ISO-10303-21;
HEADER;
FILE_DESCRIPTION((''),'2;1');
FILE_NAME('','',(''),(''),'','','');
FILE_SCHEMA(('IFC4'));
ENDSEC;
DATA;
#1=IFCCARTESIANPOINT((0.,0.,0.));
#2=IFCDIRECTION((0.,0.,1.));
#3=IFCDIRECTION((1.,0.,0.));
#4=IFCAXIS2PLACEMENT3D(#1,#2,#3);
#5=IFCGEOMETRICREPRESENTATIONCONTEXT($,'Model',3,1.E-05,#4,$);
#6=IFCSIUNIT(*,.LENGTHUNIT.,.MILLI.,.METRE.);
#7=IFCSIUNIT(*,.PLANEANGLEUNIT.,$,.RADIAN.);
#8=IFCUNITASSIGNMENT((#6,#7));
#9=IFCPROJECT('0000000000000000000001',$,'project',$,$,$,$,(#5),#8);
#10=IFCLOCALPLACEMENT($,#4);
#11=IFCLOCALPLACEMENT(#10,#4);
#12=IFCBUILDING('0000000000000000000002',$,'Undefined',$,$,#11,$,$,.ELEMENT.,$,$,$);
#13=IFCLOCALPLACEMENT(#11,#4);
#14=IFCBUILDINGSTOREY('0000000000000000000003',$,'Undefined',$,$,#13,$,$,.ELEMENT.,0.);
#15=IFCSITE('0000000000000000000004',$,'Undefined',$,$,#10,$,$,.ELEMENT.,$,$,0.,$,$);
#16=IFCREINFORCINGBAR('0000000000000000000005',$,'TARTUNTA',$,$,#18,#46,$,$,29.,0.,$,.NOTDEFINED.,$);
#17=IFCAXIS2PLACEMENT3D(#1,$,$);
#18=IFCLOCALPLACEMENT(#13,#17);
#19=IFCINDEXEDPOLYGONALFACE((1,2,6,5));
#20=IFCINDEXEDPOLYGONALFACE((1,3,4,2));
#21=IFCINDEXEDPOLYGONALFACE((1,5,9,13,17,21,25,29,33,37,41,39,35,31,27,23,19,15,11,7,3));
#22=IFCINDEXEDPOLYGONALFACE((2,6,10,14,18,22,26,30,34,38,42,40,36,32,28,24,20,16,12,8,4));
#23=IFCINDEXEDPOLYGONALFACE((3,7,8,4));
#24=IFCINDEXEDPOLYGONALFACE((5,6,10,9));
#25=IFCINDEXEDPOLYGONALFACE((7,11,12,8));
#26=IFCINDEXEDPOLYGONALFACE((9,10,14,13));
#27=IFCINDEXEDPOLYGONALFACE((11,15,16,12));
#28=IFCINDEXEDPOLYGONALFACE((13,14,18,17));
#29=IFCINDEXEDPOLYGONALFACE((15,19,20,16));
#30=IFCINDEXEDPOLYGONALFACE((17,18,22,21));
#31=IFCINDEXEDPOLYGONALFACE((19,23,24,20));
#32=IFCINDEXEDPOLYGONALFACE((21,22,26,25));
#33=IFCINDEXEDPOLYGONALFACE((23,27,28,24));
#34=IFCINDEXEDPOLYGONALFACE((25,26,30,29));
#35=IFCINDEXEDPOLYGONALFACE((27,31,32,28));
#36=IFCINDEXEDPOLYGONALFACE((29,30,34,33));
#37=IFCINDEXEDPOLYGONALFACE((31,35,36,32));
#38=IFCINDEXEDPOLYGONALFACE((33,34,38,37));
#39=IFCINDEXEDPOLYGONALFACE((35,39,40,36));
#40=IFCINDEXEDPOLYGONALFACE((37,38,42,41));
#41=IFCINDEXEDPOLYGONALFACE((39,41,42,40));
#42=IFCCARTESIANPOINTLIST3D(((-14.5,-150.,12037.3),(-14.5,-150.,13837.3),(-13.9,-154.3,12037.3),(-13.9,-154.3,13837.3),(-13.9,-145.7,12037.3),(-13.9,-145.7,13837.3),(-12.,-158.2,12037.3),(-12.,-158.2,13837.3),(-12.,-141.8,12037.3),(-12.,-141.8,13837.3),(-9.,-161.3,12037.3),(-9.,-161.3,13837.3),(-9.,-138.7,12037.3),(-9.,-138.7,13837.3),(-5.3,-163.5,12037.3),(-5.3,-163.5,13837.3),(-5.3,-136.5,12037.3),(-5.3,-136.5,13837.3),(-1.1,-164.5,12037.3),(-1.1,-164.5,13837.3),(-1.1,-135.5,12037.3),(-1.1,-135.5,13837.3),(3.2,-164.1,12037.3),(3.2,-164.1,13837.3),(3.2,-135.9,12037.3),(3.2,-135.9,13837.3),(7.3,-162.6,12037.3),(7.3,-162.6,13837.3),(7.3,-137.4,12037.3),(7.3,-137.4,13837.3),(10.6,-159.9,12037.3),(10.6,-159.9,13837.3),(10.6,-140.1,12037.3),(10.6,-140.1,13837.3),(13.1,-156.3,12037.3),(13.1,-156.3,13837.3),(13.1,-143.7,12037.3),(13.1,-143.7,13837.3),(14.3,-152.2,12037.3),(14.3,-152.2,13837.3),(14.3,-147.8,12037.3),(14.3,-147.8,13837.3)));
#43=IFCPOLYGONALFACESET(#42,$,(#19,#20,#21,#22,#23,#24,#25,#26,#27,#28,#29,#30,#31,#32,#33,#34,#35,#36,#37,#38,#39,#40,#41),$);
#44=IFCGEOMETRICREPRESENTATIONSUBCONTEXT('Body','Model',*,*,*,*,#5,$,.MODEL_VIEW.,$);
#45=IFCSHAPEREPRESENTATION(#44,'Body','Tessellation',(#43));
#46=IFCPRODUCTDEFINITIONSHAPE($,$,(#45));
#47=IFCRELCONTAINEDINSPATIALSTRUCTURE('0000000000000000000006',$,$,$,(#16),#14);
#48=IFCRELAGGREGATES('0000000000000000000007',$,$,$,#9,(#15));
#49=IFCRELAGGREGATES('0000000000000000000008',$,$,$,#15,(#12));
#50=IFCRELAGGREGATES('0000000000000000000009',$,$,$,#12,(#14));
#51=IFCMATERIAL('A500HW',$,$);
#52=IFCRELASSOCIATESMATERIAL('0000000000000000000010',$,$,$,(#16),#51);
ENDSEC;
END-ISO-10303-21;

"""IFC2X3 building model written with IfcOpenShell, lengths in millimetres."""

from ifc_helpers import new_model, entity, si_unit, frame, origin_with_axes, place, context, subcontext, project, spatial, source, transform, mapped, material, element, save


model = new_model("IFC2X3")

# Units and contexts
model_context = context("Model", 3, precision=1e-05, world=origin_with_axes())
body_context = subcontext(model_context, "Body", "Model", "MODEL_VIEW")
ifc_project = project(units=[si_unit("LENGTHUNIT", "METRE", prefix="MILLI"), si_unit("PLANEANGLEUNIT", "RADIAN")], contexts=[model_context])

# Site, building, storey
site_placement = place(None, origin_with_axes())
site = spatial("IfcSite", under=ifc_project, at=site_placement, Name="Undefined", CompositionType="ELEMENT", RefElevation=0.0)
building_placement = place(site_placement, origin_with_axes())
building = spatial("IfcBuilding", under=site, at=building_placement, Name="Undefined", CompositionType="ELEMENT")
storey_placement = place(building_placement, origin_with_axes())
storey = spatial("IfcBuildingStorey", under=building, at=storey_placement, Name="Undefined", CompositionType="ELEMENT", Elevation=0.0)

# Reinforcing bar
ifc_material_1 = material(Name="A500HW")
shared_shape_1 = source(origin_with_axes(), body_context, "Body", "AdvancedSweptSolid", [
    entity("IfcSweptDiskSolid", entity("IfcTrimmedCurve", entity("IfcLine", entity("IfcCartesianPoint", [0.0, 0.0, 0.0]), entity("IfcVector", entity("IfcDirection", [1.0, 0.0, 0.0]), 1.0)), [entity("IfcParameterValue", 0.0)], [entity("IfcParameterValue", 1799.999806)], True, "PARAMETER"), 14.5, None, 0.0, 1800.0),
])
reinforcing_bar_1_placement = place(storey_placement, frame((0.0, -150.0, 13837.3), z_axis=(-1.0, 0.0, 0.0), x_axis=(0.0, 0.0, -1.0)))
element("IfcReinforcingBar", 1, at=reinforcing_bar_1_placement, inside=storey, material=ifc_material_1, Name="TARTUNTA", BarRole="NOTDEFINED", CrossSectionArea=0.0, NominalDiameter=29.0, context=body_context, shape_type="MappedRepresentation", body=[
    mapped(shared_shape_1, transform((0.0, 0.0, 0.0))),
])

save(model, "model.ifc")
